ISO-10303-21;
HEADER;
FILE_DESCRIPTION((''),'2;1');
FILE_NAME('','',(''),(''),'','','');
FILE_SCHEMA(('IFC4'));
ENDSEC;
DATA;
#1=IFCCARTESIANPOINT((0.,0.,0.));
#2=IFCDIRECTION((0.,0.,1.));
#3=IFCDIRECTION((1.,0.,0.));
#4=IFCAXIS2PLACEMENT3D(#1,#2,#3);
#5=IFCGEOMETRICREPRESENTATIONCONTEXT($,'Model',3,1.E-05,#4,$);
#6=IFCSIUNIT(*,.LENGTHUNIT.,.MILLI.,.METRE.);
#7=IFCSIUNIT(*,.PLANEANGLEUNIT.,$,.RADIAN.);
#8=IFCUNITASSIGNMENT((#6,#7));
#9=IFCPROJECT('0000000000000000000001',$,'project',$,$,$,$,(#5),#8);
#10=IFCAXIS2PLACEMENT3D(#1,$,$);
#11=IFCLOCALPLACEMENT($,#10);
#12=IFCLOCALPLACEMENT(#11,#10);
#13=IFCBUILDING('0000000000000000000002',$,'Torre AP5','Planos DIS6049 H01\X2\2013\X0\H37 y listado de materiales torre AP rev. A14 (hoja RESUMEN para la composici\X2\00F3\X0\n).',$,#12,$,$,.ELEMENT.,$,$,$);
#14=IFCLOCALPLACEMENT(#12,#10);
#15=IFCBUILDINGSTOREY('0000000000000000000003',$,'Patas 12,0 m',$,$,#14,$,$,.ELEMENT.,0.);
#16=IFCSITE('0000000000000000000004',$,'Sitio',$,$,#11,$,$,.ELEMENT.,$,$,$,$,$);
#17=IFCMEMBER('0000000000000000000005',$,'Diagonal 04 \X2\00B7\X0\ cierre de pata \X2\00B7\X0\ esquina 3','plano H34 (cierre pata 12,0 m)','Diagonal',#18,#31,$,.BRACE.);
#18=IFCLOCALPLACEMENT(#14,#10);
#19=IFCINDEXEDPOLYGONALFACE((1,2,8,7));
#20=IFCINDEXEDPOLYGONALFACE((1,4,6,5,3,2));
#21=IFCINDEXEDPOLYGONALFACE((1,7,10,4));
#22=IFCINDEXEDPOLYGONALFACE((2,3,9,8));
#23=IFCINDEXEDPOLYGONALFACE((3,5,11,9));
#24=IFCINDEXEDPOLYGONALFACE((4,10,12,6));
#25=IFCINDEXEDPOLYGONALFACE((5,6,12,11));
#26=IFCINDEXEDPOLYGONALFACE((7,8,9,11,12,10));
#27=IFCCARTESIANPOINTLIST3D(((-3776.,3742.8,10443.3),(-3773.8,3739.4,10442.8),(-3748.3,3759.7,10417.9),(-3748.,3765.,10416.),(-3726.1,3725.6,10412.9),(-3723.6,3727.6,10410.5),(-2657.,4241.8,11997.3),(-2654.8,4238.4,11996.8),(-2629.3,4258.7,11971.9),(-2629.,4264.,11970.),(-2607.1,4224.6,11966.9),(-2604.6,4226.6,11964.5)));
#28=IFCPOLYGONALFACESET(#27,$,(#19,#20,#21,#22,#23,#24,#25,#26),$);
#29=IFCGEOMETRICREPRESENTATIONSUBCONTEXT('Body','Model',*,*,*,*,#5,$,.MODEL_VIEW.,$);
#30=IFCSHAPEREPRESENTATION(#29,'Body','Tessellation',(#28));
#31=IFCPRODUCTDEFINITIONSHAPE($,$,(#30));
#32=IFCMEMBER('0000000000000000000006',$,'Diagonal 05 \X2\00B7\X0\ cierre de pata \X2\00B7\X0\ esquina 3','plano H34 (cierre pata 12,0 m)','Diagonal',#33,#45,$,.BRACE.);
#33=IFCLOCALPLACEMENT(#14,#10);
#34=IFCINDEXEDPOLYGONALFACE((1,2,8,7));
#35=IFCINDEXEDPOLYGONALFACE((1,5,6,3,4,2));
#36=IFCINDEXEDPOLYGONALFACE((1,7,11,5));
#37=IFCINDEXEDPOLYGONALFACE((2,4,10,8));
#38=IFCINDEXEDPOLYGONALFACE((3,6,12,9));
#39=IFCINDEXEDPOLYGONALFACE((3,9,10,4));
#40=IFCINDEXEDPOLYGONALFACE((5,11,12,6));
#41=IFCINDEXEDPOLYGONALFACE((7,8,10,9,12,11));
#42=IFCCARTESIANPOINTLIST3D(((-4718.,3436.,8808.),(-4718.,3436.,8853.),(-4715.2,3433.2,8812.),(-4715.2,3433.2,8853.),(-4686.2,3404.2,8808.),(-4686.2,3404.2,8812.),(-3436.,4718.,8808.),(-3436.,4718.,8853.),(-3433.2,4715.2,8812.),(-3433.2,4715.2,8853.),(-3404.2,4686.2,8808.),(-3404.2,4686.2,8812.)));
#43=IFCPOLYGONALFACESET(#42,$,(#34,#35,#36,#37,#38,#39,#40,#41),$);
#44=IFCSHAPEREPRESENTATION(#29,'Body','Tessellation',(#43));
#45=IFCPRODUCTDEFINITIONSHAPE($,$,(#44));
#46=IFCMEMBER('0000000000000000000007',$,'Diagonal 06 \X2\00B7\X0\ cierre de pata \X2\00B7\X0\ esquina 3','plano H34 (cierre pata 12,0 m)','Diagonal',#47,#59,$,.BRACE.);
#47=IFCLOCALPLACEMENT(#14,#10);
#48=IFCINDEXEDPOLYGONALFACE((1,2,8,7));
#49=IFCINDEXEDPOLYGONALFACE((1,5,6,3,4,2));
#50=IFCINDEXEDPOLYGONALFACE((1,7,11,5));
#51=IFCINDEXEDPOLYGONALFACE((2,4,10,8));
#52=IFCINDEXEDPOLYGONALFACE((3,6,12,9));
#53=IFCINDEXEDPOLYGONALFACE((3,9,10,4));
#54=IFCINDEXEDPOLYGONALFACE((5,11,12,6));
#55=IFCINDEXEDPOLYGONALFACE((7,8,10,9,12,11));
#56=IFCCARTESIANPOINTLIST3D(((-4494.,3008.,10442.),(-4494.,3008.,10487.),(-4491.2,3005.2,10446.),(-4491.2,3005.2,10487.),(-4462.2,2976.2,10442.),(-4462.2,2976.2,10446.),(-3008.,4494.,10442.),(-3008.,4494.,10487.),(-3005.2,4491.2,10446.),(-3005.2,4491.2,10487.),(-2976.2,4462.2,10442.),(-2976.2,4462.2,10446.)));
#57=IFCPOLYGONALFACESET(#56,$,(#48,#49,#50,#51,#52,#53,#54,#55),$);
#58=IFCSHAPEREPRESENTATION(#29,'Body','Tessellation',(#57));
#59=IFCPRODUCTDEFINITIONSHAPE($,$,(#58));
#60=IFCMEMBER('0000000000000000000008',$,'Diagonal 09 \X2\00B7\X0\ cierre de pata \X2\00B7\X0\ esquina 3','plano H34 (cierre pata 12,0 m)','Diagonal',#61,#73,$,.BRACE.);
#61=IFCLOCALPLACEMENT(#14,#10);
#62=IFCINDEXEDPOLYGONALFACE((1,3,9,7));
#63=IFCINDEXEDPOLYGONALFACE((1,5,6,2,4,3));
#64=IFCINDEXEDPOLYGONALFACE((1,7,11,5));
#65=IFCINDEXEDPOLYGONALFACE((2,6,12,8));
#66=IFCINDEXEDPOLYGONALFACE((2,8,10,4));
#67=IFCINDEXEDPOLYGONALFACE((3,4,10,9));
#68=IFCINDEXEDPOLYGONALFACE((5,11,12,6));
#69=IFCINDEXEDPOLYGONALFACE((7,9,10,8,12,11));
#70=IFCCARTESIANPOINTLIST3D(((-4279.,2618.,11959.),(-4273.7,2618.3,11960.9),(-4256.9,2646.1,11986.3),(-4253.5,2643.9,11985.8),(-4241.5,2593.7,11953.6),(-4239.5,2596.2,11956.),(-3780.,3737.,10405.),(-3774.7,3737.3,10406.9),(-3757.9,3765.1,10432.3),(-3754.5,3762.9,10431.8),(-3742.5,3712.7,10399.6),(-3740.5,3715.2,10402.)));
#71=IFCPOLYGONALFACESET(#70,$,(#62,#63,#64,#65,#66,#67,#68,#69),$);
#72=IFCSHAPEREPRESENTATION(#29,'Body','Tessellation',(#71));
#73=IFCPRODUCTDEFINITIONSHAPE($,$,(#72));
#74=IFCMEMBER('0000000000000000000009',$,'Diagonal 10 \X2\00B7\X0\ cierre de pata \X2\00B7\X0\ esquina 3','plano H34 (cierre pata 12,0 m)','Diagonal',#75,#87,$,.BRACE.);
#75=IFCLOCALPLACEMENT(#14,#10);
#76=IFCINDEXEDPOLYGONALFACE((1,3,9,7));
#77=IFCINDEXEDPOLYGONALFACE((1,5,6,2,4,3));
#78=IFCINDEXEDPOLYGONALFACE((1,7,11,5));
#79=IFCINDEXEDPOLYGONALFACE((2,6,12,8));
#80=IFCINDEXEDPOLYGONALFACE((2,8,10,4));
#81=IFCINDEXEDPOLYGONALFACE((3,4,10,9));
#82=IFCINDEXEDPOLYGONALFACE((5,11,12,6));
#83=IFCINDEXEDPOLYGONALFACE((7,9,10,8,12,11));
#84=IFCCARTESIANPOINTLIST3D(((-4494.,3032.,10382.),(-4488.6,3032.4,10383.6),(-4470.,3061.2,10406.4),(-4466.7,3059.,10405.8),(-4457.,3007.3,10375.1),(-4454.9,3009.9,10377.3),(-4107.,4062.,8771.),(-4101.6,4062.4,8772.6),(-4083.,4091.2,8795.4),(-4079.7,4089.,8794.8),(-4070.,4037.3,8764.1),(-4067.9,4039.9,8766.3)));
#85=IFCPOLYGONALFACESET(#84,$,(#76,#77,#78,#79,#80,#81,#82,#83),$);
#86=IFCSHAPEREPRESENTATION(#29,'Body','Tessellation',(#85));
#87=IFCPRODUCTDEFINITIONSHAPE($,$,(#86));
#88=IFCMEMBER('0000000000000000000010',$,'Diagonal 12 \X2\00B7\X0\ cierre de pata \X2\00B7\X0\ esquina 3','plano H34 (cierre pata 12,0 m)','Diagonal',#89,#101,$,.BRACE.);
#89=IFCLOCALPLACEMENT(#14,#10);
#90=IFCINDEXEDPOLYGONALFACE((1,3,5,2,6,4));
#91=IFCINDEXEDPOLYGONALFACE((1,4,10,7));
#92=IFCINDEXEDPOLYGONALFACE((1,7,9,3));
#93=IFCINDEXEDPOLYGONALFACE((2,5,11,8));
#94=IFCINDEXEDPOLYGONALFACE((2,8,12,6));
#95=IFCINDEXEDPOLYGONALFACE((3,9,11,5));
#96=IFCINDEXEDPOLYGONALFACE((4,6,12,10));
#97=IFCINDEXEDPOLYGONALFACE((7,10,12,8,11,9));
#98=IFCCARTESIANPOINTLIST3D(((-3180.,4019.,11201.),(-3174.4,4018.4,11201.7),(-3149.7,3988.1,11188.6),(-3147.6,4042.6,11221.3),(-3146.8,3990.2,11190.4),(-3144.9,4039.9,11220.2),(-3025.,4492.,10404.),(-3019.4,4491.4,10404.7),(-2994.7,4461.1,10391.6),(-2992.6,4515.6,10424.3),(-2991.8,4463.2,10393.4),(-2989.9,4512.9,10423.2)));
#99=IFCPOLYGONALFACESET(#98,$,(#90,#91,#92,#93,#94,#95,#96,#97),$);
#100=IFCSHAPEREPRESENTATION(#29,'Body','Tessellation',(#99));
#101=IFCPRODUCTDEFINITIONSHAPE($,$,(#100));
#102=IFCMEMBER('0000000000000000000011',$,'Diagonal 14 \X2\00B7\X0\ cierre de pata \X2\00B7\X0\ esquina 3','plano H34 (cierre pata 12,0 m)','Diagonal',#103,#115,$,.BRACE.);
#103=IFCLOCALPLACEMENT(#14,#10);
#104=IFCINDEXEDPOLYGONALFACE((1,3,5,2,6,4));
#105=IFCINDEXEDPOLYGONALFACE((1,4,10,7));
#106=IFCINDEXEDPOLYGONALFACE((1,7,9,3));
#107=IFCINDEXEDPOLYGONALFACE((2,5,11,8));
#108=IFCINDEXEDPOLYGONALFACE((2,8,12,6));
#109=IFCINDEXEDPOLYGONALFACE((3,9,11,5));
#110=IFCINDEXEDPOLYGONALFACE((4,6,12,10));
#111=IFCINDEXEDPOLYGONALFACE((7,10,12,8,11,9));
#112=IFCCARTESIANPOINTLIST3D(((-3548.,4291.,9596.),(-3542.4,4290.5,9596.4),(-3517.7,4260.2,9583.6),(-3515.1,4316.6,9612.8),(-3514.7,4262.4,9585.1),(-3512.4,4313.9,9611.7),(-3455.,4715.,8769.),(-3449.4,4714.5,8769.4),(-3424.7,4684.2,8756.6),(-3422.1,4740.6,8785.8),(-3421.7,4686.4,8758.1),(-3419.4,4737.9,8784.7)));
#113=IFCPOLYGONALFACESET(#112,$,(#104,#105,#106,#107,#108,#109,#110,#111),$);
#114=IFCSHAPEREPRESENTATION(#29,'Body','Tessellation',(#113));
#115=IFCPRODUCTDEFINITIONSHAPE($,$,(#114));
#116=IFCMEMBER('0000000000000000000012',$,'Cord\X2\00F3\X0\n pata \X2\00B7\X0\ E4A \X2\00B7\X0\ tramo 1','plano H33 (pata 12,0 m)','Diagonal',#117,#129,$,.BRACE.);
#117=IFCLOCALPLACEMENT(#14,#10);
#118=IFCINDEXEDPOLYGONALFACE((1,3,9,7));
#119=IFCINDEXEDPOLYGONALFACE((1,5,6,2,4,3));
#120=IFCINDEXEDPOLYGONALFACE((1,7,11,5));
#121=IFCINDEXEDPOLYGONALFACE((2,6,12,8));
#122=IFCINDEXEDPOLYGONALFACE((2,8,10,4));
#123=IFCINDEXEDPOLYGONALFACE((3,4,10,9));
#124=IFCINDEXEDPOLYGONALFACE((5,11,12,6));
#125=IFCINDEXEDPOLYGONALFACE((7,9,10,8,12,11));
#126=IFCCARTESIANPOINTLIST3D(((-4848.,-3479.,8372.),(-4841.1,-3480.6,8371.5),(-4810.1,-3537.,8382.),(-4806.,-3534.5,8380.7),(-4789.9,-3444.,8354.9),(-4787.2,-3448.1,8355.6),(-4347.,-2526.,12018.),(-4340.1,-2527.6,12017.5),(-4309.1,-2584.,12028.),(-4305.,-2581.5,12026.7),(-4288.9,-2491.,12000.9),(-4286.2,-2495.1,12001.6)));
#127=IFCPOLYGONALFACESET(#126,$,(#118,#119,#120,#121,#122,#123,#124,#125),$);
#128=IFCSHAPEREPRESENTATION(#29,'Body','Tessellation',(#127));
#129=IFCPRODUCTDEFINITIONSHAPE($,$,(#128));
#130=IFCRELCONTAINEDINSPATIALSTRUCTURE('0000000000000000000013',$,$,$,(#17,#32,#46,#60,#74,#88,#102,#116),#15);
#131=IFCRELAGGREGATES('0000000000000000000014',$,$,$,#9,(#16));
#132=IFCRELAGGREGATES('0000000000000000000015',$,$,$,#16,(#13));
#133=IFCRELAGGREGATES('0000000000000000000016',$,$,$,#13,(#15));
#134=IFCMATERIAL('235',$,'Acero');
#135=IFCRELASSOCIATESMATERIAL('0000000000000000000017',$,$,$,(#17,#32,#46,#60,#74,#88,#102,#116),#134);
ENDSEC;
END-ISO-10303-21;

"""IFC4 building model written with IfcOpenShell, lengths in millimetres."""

from ifc_helpers import new_model, si_unit, frame, frame_2d, origin, origin_with_axes, place, context, subcontext, project, spatial, l_section, extrude, material, element, save


model = new_model("IFC4")

# Units and contexts
model_context = context("Model", 3, precision=1e-05, world=origin_with_axes())
body_context = subcontext(model_context, "Body", "Model", "MODEL_VIEW")
ifc_project = project(units=[si_unit("LENGTHUNIT", "METRE", prefix="MILLI"), si_unit("PLANEANGLEUNIT", "RADIAN")], contexts=[model_context])

# Site, building, storey
site_placement = place(None, origin())
site = spatial("IfcSite", under=ifc_project, at=site_placement, Name="Sitio", CompositionType="ELEMENT")
building_placement = place(site_placement, origin())
building = spatial("IfcBuilding", under=site, at=building_placement, Name="Torre AP5", Description="Planos DIS6049 H01–H37 y listado de materiales torre AP rev. A14 (hoja RESUMEN para la composición).", CompositionType="ELEMENT")
storey_placement = place(building_placement, origin())
storey = spatial("IfcBuildingStorey", under=building, at=storey_placement, Name="Patas 12,0 m", CompositionType="ELEMENT", Elevation=0.0)

# Members
ifc_material_1 = material(Name="235", Category="Acero")
member_1_placement = place(storey_placement, frame((-2629.0, 4264.0, 11970.0), z_axis=(-0.565463, -0.252159, -0.785281), x_axis=(0.541208, -0.831906, -0.122581)))
element("IfcMember", 1, at=member_1_placement, inside=storey, material=ifc_material_1, Name="Diagonal 04 · cierre de pata · esquina 3", Description="plano H34 (cierre pata 12,0 m)", ObjectType="Diagonal", PredefinedType="BRACE", context=body_context, shape_type="SweptSolid", body=[
    extrude(l_section(Depth=45.0, Width=45.0, Thickness=4.0, at=frame_2d((22.5, 22.5))), None, (0.0, 0.0, 1.0), 1978.9),
])
member_2_placement = place(storey_placement, frame((-3436.0, 4718.0, 8808.0), z_axis=(-0.707107, -0.707107, 0.0), x_axis=(0.707107, -0.707107, 0.0)))
element("IfcMember", 2, at=member_2_placement, inside=storey, material=ifc_material_1, Name="Diagonal 05 · cierre de pata · esquina 3", Description="plano H34 (cierre pata 12,0 m)", ObjectType="Diagonal", PredefinedType="BRACE", context=body_context, shape_type="SweptSolid", body=[
    extrude(l_section(Depth=45.0, Width=45.0, Thickness=4.0, at=frame_2d((22.5, 22.5))), None, (0.0, 0.0, 1.0), 1813.0),
])
member_3_placement = place(storey_placement, frame((-3008.0, 4494.0, 10442.0), z_axis=(-0.707107, -0.707107, 0.0), x_axis=(0.707107, -0.707107, 0.0)))
element("IfcMember", 3, at=member_3_placement, inside=storey, material=ifc_material_1, Name="Diagonal 06 · cierre de pata · esquina 3", Description="plano H34 (cierre pata 12,0 m)", ObjectType="Diagonal", PredefinedType="BRACE", context=body_context, shape_type="SweptSolid", body=[
    extrude(l_section(Depth=45.0, Width=45.0, Thickness=4.0, at=frame_2d((22.5, 22.5))), None, (0.0, 0.0, 1.0), 2101.5),
])
member_4_placement = place(storey_placement, frame((-3780.0, 3737.0, 10405.0), z_axis=(-0.252159, -0.565463, 0.785281), x_axis=(0.833293, -0.539456, -0.120874)))
element("IfcMember", 4, at=member_4_placement, inside=storey, material=ifc_material_1, Name="Diagonal 09 · cierre de pata · esquina 3", Description="plano H34 (cierre pata 12,0 m)", ObjectType="Diagonal", PredefinedType="BRACE", context=body_context, shape_type="SweptSolid", body=[
    extrude(l_section(Depth=45.0, Width=45.0, Thickness=4.0, at=frame_2d((22.5, 22.5))), None, (0.0, 0.0, 1.0), 1978.9),
])
member_5_placement = place(storey_placement, frame((-4107.0, 4062.0, 8771.0), z_axis=(-0.198371, -0.527963, 0.825775), x_axis=(0.821595, -0.548981, -0.153627)))
element("IfcMember", 5, at=member_5_placement, inside=storey, material=ifc_material_1, Name="Diagonal 10 · cierre de pata · esquina 3", Description="plano H34 (cierre pata 12,0 m)", ObjectType="Diagonal", PredefinedType="BRACE", context=body_context, shape_type="SweptSolid", body=[
    extrude(l_section(Depth=45.0, Width=45.0, Thickness=4.0, at=frame_2d((22.5, 22.5))), None, (0.0, 0.0, 1.0), 1950.9),
])
member_6_placement = place(storey_placement, frame((-3025.0, 4492.0, 10404.0), z_axis=(-0.164953, -0.503373, 0.848178), x_axis=(0.673253, -0.685914, -0.276139)))
element("IfcMember", 6, at=member_6_placement, inside=storey, material=ifc_material_1, Name="Diagonal 12 · cierre de pata · esquina 3", Description="plano H34 (cierre pata 12,0 m)", ObjectType="Diagonal", PredefinedType="BRACE", context=body_context, shape_type="SweptSolid", body=[
    extrude(l_section(Depth=45.0, Width=45.0, Thickness=4.0, at=frame_2d((22.5, 22.5))), None, (0.0, 0.0, 1.0), 939.7),
])
member_7_placement = place(storey_placement, frame((-3455.0, 4715.0, 8769.0), z_axis=(-0.099572, -0.453962, 0.88544), x_axis=(0.673907, -0.685467, -0.275653)))
element("IfcMember", 7, at=member_7_placement, inside=storey, material=ifc_material_1, Name="Diagonal 14 · cierre de pata · esquina 3", Description="plano H34 (cierre pata 12,0 m)", ObjectType="Diagonal", PredefinedType="BRACE", context=body_context, shape_type="SweptSolid", body=[
    extrude(l_section(Depth=45.0, Width=45.0, Thickness=4.0, at=frame_2d((22.5, 22.5))), None, (0.0, 0.0, 1.0), 934.0),
])
member_8_placement = place(storey_placement, frame((-4347.0, -2526.0, 12018.0), z_axis=(-0.131785, -0.250681, -0.959058), x_axis=(0.83048, 0.500329, -0.244894)))
element("IfcMember", 8, at=member_8_placement, inside=storey, material=ifc_material_1, Name="Cordón pata · E4A · tramo 1", Description="plano H33 (pata 12,0 m)", ObjectType="Diagonal", PredefinedType="BRACE", context=body_context, shape_type="SweptSolid", body=[
    extrude(l_section(Depth=70.0, Width=70.0, Thickness=5.0, at=frame_2d((35.0, 35.0))), None, (0.0, 0.0, 1.0), 3801.6),
])

save(model, "model.ifc")
